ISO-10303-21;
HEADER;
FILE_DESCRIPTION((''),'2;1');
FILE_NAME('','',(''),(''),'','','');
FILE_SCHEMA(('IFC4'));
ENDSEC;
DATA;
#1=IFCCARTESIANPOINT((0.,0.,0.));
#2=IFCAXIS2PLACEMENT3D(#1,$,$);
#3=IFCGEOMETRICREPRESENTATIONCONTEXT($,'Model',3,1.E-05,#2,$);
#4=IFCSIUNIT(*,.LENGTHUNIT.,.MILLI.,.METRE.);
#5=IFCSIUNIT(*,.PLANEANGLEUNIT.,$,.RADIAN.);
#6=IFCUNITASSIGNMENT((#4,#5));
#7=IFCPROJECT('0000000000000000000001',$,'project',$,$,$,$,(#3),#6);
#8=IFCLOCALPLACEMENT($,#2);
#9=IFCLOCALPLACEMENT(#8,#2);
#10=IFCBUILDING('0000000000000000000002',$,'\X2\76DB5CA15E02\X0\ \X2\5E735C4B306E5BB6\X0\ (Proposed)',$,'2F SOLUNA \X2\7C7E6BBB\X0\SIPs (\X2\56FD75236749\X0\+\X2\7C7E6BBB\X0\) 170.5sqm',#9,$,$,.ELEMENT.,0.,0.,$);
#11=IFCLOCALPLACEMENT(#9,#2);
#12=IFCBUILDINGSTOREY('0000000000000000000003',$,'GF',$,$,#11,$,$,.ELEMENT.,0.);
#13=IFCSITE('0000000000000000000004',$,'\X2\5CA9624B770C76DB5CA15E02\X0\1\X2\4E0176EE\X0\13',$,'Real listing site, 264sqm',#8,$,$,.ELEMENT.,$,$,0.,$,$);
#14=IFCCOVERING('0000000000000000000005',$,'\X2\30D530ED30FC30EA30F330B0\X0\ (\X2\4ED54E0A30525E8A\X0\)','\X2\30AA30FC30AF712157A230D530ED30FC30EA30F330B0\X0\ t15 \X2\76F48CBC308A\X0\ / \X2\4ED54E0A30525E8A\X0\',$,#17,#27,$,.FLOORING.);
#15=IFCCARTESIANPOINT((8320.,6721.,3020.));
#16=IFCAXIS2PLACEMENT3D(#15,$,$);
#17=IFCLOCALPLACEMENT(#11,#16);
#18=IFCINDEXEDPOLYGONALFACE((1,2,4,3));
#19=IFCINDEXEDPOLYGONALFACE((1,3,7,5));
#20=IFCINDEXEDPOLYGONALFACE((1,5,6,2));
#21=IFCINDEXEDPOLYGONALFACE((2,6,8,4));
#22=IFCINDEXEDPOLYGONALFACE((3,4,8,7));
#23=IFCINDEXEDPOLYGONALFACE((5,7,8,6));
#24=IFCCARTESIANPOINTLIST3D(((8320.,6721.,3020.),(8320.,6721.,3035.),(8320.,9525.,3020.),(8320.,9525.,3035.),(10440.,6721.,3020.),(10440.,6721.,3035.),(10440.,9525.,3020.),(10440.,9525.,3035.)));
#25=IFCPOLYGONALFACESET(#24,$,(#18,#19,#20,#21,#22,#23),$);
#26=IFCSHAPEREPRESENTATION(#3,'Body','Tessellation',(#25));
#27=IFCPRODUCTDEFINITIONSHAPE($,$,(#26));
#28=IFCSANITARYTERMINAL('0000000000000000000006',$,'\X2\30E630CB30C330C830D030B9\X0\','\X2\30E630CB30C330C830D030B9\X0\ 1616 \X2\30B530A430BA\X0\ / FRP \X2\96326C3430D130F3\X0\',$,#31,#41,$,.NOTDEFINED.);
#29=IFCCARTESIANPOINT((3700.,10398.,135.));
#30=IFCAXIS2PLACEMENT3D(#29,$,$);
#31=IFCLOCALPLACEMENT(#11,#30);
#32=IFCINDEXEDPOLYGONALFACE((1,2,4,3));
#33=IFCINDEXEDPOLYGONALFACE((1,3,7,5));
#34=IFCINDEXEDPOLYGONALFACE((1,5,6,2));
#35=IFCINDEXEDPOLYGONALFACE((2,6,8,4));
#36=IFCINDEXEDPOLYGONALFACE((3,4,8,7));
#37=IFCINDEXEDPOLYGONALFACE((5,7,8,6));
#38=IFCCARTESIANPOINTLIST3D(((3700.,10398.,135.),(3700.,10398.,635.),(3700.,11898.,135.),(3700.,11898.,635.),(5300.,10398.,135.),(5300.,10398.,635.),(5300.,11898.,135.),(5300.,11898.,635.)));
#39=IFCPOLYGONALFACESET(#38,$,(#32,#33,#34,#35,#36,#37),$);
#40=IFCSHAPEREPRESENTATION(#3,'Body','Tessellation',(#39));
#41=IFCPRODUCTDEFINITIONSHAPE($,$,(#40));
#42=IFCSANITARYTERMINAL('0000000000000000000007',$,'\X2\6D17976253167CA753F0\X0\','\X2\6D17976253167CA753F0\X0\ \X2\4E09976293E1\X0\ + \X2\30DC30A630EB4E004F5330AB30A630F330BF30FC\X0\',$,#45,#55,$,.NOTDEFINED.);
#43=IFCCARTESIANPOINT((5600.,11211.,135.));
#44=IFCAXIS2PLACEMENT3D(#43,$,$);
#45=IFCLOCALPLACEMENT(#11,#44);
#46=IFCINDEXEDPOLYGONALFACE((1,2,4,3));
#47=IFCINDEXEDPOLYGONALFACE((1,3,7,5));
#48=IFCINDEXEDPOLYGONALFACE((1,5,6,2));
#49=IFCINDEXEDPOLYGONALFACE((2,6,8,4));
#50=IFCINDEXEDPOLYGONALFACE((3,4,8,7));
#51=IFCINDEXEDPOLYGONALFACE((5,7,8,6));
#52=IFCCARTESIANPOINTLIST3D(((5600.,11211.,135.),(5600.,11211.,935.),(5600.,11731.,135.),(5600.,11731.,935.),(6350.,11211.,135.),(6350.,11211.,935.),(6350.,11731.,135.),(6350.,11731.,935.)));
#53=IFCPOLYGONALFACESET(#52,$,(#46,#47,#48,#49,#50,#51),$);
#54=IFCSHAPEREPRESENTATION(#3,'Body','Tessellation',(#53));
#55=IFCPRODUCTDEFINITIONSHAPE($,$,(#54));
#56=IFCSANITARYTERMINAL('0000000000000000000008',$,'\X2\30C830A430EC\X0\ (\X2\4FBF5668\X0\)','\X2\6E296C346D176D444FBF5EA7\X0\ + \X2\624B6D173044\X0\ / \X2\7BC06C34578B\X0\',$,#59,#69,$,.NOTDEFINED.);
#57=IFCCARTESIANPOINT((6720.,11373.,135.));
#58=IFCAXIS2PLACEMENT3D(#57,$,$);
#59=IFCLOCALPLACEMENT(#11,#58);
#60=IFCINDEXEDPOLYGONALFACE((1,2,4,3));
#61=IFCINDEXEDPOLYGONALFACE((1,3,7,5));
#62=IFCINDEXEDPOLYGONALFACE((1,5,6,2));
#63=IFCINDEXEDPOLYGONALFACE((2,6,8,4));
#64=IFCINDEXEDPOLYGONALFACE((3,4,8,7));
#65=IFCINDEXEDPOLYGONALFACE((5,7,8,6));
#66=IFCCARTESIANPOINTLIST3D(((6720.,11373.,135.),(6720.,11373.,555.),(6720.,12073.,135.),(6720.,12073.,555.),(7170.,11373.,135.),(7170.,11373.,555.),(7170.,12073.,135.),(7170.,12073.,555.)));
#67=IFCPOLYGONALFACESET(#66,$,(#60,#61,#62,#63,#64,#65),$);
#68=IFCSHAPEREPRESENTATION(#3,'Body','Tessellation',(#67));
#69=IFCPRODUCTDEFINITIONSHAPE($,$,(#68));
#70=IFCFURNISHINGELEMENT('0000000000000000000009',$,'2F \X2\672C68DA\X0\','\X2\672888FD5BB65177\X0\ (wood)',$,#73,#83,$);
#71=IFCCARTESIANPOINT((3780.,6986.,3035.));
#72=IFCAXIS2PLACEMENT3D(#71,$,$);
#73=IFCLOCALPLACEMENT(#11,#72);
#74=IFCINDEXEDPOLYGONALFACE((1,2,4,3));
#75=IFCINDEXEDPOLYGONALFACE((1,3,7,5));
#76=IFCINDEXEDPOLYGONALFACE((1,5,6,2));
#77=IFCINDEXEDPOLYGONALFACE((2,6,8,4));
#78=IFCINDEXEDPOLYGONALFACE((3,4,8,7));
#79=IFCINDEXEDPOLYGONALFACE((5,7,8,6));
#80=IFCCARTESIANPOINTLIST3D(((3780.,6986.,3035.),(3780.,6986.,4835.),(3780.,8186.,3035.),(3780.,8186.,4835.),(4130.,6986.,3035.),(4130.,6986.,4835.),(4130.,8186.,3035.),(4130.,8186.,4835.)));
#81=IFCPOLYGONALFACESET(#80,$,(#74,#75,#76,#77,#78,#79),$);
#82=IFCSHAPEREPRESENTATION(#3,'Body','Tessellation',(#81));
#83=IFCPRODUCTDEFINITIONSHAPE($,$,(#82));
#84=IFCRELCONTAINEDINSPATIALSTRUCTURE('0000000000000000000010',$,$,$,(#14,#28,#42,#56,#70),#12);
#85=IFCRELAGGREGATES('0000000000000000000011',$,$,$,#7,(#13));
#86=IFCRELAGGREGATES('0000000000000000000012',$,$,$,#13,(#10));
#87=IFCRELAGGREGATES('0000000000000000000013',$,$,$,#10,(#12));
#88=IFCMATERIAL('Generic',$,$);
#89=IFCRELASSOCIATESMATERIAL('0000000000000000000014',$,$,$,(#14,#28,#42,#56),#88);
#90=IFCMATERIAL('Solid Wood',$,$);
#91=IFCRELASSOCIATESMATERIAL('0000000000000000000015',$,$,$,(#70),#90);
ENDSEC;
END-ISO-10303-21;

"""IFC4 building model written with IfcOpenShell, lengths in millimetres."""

from ifc_helpers import new_model, si_unit, frame, frame_2d, origin, place, context, project, spatial, rectangle, extrude, material, element, save


model = new_model("IFC4")

# Units and contexts
model_context = context("Model", 3, precision=1e-05, world=origin())
ifc_project = project(units=[si_unit("LENGTHUNIT", "METRE", prefix="MILLI"), si_unit("PLANEANGLEUNIT", "RADIAN")], contexts=[model_context])

# Site, building, storey
site_placement = place(None, origin())
site = spatial("IfcSite", under=ifc_project, at=site_placement, Name="岩手県盛岡市1丁目13", ObjectType="Real listing site, 264sqm", CompositionType="ELEMENT", RefElevation=0.0)
building_placement = place(site_placement, origin())
building = spatial("IfcBuilding", under=site, at=building_placement, Name="盛岡市 平屋の家 (Proposed)", ObjectType="2F SOLUNA 籾殻SIPs (国産杉+籾殻) 170.5sqm", CompositionType="ELEMENT", ElevationOfRefHeight=0.0, ElevationOfTerrain=0.0)
storey_placement = place(building_placement, origin())
storey = spatial("IfcBuildingStorey", under=building, at=storey_placement, Name="GF", CompositionType="ELEMENT", Elevation=0.0)

# Shared definitions
ifc_material_1 = material(Name="Solid Wood")
ifc_material_2 = material(Name="Generic")

# Covering
covering_1_placement = place(storey_placement, frame((8320.0, 6721.0, 3020.0)))
element("IfcCovering", 1, at=covering_1_placement, inside=storey, material=ifc_material_2, Name="フローリング (仕上げ床)", Description="オーク無垢フローリング t15 直貼り / 仕上げ床", PredefinedType="FLOORING", context=model_context, shape_type="SweptSolid", body=[
    extrude(rectangle(XDim=2120.0, YDim=2804.0, at=frame_2d((1060.0, 1402.0))), frame((8320.0, 6721.0, 3020.0)), (0.0, 0.0, 1.0), 15.0),
])

# Sanitary terminals
sanitary_terminal_1_placement = place(storey_placement, frame((3700.0, 10398.0, 135.0)))
element("IfcSanitaryTerminal", 2, at=sanitary_terminal_1_placement, inside=storey, material=ifc_material_2, Name="ユニットバス", Description="ユニットバス 1616 サイズ / FRP 防水パン", PredefinedType="NOTDEFINED", context=model_context, shape_type="SweptSolid", body=[
    extrude(rectangle(XDim=1600.0, YDim=1500.0, at=frame_2d((800.0, 750.0))), frame((3700.0, 10398.0, 135.0)), (0.0, 0.0, 1.0), 500.0),
])
sanitary_terminal_2_placement = place(storey_placement, frame((5600.0, 11211.0, 135.0)))
element("IfcSanitaryTerminal", 3, at=sanitary_terminal_2_placement, inside=storey, material=ifc_material_2, Name="洗面化粧台", Description="洗面化粧台 三面鏡 + ボウル一体カウンター", PredefinedType="NOTDEFINED", context=model_context, shape_type="SweptSolid", body=[
    extrude(rectangle(XDim=750.0, YDim=520.0, at=frame_2d((375.0, 260.0))), frame((5600.0, 11211.0, 135.0)), (0.0, 0.0, 1.0), 800.0),
])
sanitary_terminal_3_placement = place(storey_placement, frame((6720.0, 11373.0, 135.0)))
element("IfcSanitaryTerminal", 4, at=sanitary_terminal_3_placement, inside=storey, material=ifc_material_2, Name="トイレ (便器)", Description="温水洗浄便座 + 手洗い / 節水型", PredefinedType="NOTDEFINED", context=model_context, shape_type="SweptSolid", body=[
    extrude(rectangle(XDim=450.0, YDim=700.0, at=frame_2d((225.0, 350.0))), frame((6720.0, 11373.0, 135.0)), (0.0, 0.0, 1.0), 420.0),
])

# Furnishing element
furnishing_placement = place(storey_placement, frame((3780.0, 6986.0, 3035.0)))
element("IfcFurnishingElement", 5, at=furnishing_placement, inside=storey, material=ifc_material_1, Name="2F 本棚", Description="木製家具 (wood)", context=model_context, shape_type="SweptSolid", body=[
    extrude(rectangle(XDim=350.0, YDim=1200.0, at=frame_2d((175.0, 600.0))), frame((3780.0, 6986.0, 3035.0)), (0.0, 0.0, 1.0), 1800.0),
])

save(model, "model.ifc")
